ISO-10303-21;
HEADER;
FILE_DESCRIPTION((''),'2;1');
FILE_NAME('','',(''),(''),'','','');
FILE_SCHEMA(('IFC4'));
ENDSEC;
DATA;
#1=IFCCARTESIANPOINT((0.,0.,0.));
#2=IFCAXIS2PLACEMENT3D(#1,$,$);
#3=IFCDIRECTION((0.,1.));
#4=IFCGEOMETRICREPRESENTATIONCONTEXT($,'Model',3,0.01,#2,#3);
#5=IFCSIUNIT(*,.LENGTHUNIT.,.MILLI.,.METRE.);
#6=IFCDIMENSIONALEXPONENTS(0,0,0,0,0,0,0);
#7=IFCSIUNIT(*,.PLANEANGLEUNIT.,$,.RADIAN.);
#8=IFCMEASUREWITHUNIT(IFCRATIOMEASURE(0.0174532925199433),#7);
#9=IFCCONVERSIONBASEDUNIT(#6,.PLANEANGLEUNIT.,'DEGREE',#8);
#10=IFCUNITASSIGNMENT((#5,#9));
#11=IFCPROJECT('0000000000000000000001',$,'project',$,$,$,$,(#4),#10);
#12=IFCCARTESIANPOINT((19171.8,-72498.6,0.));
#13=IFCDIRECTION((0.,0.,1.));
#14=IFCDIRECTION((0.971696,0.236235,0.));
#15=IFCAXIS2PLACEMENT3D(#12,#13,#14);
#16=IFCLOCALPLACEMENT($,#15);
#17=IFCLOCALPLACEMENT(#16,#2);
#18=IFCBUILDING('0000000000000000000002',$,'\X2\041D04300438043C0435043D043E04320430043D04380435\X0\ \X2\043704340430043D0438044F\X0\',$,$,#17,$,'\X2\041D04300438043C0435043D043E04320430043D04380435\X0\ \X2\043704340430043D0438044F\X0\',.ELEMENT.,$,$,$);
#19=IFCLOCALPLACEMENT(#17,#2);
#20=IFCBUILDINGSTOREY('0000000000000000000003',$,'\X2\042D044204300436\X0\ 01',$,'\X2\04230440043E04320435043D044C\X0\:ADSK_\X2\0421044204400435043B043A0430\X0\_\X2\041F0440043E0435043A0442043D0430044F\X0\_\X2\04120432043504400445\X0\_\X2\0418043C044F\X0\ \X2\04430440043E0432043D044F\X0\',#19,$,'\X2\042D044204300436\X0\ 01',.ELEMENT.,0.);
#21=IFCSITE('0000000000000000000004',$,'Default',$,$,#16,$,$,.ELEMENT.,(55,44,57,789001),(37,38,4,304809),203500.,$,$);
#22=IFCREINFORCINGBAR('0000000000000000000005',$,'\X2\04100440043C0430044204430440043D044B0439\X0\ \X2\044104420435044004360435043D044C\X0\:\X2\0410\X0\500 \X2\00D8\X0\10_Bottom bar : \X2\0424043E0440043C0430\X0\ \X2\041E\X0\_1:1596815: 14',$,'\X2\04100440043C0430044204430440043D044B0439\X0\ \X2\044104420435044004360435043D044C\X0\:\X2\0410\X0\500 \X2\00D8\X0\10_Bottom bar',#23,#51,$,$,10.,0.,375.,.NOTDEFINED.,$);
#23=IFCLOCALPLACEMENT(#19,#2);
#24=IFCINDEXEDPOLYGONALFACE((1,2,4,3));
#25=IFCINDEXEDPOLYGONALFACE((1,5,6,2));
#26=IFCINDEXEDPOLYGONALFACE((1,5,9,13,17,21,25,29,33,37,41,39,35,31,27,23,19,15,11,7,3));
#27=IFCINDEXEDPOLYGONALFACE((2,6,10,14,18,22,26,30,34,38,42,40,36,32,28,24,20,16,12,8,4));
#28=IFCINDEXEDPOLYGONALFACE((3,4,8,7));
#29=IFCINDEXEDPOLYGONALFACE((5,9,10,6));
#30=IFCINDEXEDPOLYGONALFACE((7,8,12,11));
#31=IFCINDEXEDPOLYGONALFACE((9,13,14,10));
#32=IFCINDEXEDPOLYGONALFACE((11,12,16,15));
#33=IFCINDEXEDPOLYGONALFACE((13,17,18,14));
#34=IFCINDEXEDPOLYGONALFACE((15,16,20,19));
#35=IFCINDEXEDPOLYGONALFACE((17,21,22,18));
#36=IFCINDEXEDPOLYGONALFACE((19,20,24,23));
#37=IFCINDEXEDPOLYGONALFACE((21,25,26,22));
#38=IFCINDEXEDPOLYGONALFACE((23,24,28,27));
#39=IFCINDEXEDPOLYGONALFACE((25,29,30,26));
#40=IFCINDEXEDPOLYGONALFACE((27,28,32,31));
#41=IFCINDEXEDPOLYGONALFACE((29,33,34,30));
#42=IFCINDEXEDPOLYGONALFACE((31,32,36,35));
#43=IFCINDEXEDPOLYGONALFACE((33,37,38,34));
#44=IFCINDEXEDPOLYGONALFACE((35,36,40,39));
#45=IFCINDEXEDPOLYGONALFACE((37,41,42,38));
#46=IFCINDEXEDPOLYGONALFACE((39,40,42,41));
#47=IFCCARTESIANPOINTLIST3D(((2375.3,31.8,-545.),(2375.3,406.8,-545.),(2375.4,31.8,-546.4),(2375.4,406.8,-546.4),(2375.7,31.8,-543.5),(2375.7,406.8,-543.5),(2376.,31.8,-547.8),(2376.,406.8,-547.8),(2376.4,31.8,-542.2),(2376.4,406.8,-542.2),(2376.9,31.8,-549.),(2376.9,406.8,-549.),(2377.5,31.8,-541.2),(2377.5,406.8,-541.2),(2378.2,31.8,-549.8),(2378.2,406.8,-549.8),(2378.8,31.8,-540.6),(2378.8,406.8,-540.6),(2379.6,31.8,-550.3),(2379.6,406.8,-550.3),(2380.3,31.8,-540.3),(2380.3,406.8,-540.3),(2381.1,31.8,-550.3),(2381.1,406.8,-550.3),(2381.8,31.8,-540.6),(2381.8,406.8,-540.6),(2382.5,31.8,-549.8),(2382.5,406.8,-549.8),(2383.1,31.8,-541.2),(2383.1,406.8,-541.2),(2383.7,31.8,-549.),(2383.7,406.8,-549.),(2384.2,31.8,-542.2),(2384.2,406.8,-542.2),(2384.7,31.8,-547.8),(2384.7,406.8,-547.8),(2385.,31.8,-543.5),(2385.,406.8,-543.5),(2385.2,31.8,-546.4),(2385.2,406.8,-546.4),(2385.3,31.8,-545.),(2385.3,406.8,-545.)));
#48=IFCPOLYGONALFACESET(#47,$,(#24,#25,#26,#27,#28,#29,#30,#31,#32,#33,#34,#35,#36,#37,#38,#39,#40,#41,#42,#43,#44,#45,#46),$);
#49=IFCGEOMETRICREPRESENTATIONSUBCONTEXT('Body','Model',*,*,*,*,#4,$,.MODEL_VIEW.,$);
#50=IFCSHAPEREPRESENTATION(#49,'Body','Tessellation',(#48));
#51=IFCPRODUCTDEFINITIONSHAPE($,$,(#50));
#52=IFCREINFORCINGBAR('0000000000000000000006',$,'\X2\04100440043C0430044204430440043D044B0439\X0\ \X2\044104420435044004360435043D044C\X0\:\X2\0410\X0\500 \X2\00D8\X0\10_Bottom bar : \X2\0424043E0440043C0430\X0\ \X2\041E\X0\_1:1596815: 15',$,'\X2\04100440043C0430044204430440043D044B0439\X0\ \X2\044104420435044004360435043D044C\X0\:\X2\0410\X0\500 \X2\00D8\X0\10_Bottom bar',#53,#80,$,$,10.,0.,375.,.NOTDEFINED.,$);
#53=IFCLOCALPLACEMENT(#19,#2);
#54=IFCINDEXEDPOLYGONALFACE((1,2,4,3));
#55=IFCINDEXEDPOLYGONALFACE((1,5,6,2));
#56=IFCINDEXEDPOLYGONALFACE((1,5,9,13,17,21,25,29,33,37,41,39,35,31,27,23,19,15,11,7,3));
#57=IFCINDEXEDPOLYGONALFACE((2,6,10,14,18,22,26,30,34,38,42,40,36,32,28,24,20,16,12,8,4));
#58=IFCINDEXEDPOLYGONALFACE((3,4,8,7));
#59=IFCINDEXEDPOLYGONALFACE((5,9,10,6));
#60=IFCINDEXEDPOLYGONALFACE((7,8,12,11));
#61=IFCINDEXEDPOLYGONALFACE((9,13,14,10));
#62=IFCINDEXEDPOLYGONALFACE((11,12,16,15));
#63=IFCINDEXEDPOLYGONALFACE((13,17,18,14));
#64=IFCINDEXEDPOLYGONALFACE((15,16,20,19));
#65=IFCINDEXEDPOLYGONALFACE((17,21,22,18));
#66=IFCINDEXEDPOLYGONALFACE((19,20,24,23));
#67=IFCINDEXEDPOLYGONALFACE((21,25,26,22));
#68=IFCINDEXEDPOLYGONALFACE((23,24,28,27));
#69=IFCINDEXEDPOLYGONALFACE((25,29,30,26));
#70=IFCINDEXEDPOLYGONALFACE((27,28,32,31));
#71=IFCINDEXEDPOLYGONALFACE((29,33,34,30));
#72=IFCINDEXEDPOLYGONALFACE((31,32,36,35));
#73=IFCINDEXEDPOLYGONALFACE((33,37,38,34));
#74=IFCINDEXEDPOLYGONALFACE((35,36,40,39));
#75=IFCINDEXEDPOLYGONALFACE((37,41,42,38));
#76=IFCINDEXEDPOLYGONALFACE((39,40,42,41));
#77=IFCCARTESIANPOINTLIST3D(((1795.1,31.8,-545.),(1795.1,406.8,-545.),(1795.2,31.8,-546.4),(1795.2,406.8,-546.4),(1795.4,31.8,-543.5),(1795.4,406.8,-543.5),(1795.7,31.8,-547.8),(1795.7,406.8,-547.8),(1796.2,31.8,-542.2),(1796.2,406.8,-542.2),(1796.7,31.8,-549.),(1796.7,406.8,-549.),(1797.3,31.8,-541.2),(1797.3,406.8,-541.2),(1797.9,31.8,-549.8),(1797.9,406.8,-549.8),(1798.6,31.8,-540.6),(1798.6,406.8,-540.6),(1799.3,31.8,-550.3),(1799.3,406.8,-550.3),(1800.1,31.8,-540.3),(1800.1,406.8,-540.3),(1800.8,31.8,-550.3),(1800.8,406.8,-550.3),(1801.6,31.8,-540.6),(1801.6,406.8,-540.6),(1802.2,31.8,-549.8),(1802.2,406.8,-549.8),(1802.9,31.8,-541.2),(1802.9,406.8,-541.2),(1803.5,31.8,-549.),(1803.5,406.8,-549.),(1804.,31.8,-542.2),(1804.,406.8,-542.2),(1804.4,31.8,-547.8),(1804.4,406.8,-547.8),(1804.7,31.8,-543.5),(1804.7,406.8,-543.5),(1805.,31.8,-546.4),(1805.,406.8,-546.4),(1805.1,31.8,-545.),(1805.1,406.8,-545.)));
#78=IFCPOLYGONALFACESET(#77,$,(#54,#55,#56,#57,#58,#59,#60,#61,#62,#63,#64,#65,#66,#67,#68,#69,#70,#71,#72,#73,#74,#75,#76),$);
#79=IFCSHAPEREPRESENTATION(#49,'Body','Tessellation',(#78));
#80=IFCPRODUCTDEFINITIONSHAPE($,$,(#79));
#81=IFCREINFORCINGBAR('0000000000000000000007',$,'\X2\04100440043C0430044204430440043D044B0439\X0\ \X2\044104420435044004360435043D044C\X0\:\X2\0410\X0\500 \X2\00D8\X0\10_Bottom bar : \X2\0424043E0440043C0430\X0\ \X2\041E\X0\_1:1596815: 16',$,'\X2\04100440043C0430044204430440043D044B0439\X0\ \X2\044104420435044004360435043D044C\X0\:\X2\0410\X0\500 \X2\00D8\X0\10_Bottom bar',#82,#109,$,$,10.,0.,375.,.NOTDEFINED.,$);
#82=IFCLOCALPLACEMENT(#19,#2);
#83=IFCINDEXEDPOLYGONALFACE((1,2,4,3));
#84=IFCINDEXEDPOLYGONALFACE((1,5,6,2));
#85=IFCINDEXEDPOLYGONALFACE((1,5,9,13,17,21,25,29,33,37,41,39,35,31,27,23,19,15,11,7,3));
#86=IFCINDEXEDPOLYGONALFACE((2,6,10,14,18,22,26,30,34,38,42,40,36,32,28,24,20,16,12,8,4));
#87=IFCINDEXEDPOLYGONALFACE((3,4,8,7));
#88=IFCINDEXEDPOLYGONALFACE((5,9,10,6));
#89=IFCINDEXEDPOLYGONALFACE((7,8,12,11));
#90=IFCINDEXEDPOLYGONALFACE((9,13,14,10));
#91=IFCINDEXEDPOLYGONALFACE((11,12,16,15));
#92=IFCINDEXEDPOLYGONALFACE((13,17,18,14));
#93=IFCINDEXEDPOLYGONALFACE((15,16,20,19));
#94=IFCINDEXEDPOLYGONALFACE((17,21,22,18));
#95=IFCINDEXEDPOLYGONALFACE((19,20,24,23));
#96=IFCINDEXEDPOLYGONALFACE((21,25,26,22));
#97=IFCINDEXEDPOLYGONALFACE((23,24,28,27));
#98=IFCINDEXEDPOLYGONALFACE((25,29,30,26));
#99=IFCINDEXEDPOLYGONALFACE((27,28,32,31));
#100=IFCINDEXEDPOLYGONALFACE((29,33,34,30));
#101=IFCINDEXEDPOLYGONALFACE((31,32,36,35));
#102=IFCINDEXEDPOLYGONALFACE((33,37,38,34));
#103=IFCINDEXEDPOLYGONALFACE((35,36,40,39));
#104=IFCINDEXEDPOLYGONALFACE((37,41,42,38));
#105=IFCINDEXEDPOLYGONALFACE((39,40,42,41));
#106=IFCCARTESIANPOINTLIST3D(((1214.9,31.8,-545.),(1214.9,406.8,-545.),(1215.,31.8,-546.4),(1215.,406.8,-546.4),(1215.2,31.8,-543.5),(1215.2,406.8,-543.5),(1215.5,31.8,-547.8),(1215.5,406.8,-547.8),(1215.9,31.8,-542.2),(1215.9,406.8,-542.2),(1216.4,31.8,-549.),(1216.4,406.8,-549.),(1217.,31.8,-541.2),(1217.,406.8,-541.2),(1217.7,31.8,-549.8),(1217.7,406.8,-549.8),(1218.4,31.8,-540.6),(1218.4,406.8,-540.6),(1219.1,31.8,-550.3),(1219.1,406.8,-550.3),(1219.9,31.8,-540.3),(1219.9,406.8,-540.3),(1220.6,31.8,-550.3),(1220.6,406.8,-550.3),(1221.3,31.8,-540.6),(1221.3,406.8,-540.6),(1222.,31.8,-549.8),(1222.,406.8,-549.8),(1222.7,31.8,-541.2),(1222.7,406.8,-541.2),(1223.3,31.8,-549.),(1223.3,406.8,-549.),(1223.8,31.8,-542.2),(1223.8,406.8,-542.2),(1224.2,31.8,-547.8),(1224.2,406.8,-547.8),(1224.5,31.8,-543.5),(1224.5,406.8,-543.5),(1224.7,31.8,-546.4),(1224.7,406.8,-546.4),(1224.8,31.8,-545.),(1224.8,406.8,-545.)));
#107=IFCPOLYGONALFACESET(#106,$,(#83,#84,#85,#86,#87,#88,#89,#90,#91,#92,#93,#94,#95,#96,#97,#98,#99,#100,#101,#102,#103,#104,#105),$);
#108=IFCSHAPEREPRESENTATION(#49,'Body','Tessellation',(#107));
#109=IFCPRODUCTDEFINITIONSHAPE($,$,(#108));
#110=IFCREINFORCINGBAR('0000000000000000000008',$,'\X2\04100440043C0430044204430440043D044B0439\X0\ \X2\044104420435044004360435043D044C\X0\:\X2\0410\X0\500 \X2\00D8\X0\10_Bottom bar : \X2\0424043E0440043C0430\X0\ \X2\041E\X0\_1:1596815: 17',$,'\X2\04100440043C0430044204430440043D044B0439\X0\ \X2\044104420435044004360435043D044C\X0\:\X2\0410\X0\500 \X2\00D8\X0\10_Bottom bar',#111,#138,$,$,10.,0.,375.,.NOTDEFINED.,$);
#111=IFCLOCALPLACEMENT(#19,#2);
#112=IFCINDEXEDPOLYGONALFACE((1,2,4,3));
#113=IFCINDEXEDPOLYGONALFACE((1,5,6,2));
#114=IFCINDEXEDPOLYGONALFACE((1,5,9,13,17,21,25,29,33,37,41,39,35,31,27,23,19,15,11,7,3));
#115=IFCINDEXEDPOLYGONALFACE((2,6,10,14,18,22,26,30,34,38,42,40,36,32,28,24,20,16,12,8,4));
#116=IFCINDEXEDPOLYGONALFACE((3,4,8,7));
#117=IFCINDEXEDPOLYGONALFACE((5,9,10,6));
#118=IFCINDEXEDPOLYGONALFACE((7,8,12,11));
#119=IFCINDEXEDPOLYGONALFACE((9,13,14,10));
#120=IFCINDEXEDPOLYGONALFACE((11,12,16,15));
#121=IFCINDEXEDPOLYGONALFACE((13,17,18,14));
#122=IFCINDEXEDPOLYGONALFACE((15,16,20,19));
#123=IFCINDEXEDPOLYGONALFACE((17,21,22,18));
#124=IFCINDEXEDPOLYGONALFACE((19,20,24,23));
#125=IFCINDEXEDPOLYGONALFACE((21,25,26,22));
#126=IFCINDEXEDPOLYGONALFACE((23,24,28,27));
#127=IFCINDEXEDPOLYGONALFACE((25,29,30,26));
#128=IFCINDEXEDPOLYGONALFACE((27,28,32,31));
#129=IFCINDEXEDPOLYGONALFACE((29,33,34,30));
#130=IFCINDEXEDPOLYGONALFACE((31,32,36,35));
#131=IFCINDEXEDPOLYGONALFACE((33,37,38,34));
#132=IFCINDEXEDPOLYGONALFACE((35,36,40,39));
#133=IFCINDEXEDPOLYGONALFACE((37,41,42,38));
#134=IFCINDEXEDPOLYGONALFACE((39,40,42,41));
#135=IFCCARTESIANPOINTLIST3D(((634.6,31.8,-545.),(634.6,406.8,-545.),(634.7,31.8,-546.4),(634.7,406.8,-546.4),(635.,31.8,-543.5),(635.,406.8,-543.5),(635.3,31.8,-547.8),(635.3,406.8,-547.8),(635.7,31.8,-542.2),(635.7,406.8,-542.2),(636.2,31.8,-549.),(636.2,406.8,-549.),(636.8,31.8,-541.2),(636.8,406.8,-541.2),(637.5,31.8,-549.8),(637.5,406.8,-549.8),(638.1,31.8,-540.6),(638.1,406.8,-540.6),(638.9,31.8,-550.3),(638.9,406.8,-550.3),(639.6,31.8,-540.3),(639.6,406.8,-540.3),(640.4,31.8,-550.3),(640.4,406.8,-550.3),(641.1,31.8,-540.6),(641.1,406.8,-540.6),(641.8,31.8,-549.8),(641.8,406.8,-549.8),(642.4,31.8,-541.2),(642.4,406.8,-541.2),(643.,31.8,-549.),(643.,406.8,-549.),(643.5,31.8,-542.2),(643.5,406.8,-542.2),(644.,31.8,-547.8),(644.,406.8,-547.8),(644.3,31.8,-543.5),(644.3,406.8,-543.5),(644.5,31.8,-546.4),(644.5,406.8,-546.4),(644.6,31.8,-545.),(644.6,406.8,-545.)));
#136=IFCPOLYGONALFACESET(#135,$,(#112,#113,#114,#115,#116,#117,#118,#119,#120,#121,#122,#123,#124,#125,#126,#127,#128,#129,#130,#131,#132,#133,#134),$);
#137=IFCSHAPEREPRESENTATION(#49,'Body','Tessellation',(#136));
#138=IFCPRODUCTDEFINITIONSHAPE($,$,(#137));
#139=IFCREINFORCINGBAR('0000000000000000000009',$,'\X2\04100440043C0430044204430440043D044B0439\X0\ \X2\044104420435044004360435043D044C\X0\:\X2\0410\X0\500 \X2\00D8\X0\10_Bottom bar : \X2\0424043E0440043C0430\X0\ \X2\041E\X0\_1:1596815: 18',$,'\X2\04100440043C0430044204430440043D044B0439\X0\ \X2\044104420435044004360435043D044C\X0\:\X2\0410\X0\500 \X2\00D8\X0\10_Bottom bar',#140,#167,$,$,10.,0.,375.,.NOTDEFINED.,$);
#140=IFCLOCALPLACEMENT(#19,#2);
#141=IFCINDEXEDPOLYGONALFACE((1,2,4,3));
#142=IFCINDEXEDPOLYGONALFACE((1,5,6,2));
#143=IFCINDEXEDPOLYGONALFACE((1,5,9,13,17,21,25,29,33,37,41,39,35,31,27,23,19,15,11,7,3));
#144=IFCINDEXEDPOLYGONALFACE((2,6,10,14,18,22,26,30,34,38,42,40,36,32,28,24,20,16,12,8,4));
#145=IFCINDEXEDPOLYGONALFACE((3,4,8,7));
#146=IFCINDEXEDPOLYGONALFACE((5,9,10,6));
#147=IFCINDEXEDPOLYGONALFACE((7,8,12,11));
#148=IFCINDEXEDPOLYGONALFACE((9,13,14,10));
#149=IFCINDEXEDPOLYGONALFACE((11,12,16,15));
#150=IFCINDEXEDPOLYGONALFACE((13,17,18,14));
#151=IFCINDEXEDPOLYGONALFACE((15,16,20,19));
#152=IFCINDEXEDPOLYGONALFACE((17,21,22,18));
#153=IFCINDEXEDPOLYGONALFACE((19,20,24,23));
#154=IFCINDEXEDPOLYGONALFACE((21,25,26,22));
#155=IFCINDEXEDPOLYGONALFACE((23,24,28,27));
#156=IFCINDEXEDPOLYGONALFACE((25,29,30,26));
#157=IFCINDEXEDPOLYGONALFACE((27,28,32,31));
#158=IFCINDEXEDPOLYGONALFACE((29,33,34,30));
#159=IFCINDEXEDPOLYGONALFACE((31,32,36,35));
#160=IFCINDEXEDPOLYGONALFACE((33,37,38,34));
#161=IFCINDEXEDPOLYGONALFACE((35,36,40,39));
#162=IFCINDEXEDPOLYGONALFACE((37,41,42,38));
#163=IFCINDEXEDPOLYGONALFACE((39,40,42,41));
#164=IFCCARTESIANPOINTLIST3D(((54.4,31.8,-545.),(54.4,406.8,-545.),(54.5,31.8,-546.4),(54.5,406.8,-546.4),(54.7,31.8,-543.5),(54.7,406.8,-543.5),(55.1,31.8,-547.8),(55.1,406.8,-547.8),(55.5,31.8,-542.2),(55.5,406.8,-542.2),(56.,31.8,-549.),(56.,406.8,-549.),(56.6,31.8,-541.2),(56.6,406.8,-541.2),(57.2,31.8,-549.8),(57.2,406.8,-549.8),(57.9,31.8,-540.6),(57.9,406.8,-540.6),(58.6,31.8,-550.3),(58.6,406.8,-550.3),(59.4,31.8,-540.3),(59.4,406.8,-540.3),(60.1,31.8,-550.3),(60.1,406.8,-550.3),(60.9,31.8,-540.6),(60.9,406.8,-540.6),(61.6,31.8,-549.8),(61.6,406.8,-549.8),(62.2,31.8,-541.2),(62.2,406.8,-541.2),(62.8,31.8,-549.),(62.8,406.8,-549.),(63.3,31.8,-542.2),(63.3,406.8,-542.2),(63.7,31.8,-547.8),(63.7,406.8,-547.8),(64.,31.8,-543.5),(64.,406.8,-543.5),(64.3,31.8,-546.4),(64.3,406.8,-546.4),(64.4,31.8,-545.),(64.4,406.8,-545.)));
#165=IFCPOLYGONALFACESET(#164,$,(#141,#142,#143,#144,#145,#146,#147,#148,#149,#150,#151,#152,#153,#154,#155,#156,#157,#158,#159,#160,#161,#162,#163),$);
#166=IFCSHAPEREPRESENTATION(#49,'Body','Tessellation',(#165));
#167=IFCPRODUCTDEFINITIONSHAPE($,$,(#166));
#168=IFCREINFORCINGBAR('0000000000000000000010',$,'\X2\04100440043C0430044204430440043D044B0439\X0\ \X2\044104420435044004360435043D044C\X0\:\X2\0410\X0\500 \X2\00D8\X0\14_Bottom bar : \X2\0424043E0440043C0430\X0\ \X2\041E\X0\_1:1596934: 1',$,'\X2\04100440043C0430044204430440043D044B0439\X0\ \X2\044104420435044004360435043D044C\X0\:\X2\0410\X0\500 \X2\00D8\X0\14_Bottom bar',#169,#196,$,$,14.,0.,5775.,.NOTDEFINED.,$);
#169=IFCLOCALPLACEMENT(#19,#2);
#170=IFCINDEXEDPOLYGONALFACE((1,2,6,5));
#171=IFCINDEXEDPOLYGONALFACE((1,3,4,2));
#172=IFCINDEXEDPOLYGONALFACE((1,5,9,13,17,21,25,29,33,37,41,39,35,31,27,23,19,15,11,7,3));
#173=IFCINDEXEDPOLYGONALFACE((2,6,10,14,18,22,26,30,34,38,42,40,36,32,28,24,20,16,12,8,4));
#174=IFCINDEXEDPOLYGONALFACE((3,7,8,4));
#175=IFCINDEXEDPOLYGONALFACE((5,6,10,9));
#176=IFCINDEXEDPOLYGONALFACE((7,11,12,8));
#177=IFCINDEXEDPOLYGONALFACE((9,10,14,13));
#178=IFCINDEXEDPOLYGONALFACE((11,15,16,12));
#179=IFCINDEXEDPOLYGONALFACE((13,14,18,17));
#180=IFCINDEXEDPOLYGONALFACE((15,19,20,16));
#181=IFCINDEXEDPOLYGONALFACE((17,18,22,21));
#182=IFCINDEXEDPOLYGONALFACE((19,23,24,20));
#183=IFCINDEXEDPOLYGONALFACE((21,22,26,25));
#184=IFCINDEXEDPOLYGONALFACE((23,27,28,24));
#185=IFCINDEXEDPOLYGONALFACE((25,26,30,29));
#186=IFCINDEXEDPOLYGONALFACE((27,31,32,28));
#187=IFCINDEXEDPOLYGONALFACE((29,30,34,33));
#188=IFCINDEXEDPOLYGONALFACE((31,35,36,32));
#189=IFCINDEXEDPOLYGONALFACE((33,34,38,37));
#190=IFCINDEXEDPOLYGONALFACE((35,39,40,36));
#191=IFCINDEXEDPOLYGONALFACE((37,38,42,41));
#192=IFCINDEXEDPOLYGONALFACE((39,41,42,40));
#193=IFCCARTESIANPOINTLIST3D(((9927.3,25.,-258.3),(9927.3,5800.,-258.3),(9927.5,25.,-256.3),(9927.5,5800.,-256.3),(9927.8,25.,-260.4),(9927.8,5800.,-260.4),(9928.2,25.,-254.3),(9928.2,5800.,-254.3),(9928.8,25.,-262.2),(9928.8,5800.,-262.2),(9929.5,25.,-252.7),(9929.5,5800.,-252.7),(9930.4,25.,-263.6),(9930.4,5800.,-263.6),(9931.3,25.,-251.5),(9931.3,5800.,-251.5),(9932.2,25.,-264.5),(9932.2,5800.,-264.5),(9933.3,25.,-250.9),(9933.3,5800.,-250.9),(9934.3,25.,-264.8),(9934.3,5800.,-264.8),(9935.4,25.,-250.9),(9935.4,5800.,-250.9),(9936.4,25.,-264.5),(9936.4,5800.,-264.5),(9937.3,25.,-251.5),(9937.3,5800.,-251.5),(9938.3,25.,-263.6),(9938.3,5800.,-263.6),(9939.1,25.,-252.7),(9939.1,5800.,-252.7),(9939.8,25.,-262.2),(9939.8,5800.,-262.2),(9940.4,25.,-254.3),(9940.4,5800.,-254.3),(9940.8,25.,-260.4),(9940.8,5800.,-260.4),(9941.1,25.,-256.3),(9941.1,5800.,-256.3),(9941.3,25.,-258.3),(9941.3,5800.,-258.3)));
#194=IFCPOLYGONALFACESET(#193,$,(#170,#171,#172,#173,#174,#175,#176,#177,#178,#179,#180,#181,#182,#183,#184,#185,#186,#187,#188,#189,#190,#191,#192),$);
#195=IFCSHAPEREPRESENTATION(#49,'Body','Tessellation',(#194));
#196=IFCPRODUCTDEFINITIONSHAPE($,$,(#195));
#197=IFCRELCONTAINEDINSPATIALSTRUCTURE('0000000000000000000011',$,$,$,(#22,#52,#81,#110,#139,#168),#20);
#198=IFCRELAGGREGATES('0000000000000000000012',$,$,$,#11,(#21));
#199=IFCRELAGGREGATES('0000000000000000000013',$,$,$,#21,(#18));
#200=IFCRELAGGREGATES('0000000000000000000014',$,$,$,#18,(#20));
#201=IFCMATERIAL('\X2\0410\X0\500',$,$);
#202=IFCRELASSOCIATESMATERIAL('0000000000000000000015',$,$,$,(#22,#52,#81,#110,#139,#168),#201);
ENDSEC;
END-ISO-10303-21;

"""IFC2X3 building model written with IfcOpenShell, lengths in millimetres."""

from ifc_helpers import new_model, entity, si_unit, converted_unit, direction, frame, origin, place, context, subcontext, project, spatial, material, element, save


model = new_model("IFC2X3")

# Units and contexts
model_context = context("Model", 3, precision=0.01, world=origin(), true_north=direction((0.0, 1.0)))
body_context = subcontext(model_context, "Body", "Model", "MODEL_VIEW")
ifc_project = project(units=[si_unit("LENGTHUNIT", "METRE", prefix="MILLI"), converted_unit("PLANEANGLEUNIT", "DEGREE", entity("IfcRatioMeasure", 0.0174532925199433), si_unit("PLANEANGLEUNIT", "RADIAN"), dimensions=[0, 0, 0, 0, 0, 0, 0])], contexts=[model_context])

# Site, building, storey
site_placement = place(None, frame((19171.8, -72498.6, 0.0), z_axis=(0.0, 0.0, 1.0), x_axis=(0.971696, 0.236235, 0.0)))
site = spatial("IfcSite", under=ifc_project, at=site_placement, Name="Default", CompositionType="ELEMENT", RefLatitude=(55, 44, 57, 789001), RefLongitude=(37, 38, 4, 304809), RefElevation=203500.0)
building_placement = place(site_placement, origin())
building = spatial("IfcBuilding", under=site, at=building_placement, Name="Наименование здания", LongName="Наименование здания", CompositionType="ELEMENT")
storey_placement = place(building_placement, origin())
storey = spatial("IfcBuildingStorey", under=building, at=storey_placement, Name="Этаж 01", ObjectType="Уровень:ADSK_Стрелка_Проектная_Вверх_Имя уровня", LongName="Этаж 01", CompositionType="ELEMENT", Elevation=0.0)

# Reinforcing bars
ifc_material = material(Name="А500")
placement = place(storey_placement, origin())
element("IfcReinforcingBar", 1, at=placement, inside=storey, material=ifc_material, Name="Арматурный стержень:А500 Ø10_Bottom bar : Форма О_1:1596815: 14", ObjectType="Арматурный стержень:А500 Ø10_Bottom bar", BarLength=375.0, BarRole="NOTDEFINED", CrossSectionArea=0.0, NominalDiameter=10.0, context=body_context, shape_type="AdvancedSweptSolid", body=[
    entity("IfcSweptDiskSolid", entity("IfcCompositeCurve", [entity("IfcCompositeCurveSegment", "CONTINUOUS", True, entity("IfcPolyline", [entity("IfcCartesianPoint", [2380.3, 31.8, -545.3]), entity("IfcCartesianPoint", [2380.3, 406.8, -545.3])]))], False), 5.0, None, 0.0, 1.0),
])
element("IfcReinforcingBar", 2, at=placement, inside=storey, material=ifc_material, Name="Арматурный стержень:А500 Ø10_Bottom bar : Форма О_1:1596815: 15", ObjectType="Арматурный стержень:А500 Ø10_Bottom bar", BarLength=375.0, BarRole="NOTDEFINED", CrossSectionArea=0.0, NominalDiameter=10.0, context=body_context, shape_type="AdvancedSweptSolid", body=[
    entity("IfcSweptDiskSolid", entity("IfcCompositeCurve", [entity("IfcCompositeCurveSegment", "CONTINUOUS", True, entity("IfcPolyline", [entity("IfcCartesianPoint", [1800.1, 31.8, -545.3]), entity("IfcCartesianPoint", [1800.1, 406.8, -545.3])]))], False), 5.0, None, 0.0, 1.0),
])
element("IfcReinforcingBar", 3, at=placement, inside=storey, material=ifc_material, Name="Арматурный стержень:А500 Ø10_Bottom bar : Форма О_1:1596815: 16", ObjectType="Арматурный стержень:А500 Ø10_Bottom bar", BarLength=375.0, BarRole="NOTDEFINED", CrossSectionArea=0.0, NominalDiameter=10.0, context=body_context, shape_type="AdvancedSweptSolid", body=[
    entity("IfcSweptDiskSolid", entity("IfcCompositeCurve", [entity("IfcCompositeCurveSegment", "CONTINUOUS", True, entity("IfcPolyline", [entity("IfcCartesianPoint", [1219.8, 31.8, -545.3]), entity("IfcCartesianPoint", [1219.8, 406.8, -545.3])]))], False), 5.0, None, 0.0, 1.0),
])
element("IfcReinforcingBar", 4, at=placement, inside=storey, material=ifc_material, Name="Арматурный стержень:А500 Ø10_Bottom bar : Форма О_1:1596815: 17", ObjectType="Арматурный стержень:А500 Ø10_Bottom bar", BarLength=375.0, BarRole="NOTDEFINED", CrossSectionArea=0.0, NominalDiameter=10.0, context=body_context, shape_type="AdvancedSweptSolid", body=[
    entity("IfcSweptDiskSolid", entity("IfcCompositeCurve", [entity("IfcCompositeCurveSegment", "CONTINUOUS", True, entity("IfcPolyline", [entity("IfcCartesianPoint", [639.6, 31.8, -545.3]), entity("IfcCartesianPoint", [639.6, 406.8, -545.3])]))], False), 5.0, None, 0.0, 1.0),
])
element("IfcReinforcingBar", 5, at=placement, inside=storey, material=ifc_material, Name="Арматурный стержень:А500 Ø10_Bottom bar : Форма О_1:1596815: 18", ObjectType="Арматурный стержень:А500 Ø10_Bottom bar", BarLength=375.0, BarRole="NOTDEFINED", CrossSectionArea=0.0, NominalDiameter=10.0, context=body_context, shape_type="AdvancedSweptSolid", body=[
    entity("IfcSweptDiskSolid", entity("IfcCompositeCurve", [entity("IfcCompositeCurveSegment", "CONTINUOUS", True, entity("IfcPolyline", [entity("IfcCartesianPoint", [59.4, 31.8, -545.3]), entity("IfcCartesianPoint", [59.4, 406.8, -545.3])]))], False), 5.0, None, 0.0, 1.0),
])
element("IfcReinforcingBar", 6, at=placement, inside=storey, material=ifc_material, Name="Арматурный стержень:А500 Ø14_Bottom bar : Форма О_1:1596934: 1", ObjectType="Арматурный стержень:А500 Ø14_Bottom bar", BarLength=5775.0, BarRole="NOTDEFINED", CrossSectionArea=0.0, NominalDiameter=14.0, context=body_context, shape_type="AdvancedSweptSolid", body=[
    entity("IfcSweptDiskSolid", entity("IfcCompositeCurve", [entity("IfcCompositeCurveSegment", "CONTINUOUS", True, entity("IfcPolyline", [entity("IfcCartesianPoint", [9934.3, 5800.0, -257.8]), entity("IfcCartesianPoint", [9934.3, 25.0, -257.8])]))], False), 7.0, None, 0.0, 1.0),
])

save(model, "model.ifc")
